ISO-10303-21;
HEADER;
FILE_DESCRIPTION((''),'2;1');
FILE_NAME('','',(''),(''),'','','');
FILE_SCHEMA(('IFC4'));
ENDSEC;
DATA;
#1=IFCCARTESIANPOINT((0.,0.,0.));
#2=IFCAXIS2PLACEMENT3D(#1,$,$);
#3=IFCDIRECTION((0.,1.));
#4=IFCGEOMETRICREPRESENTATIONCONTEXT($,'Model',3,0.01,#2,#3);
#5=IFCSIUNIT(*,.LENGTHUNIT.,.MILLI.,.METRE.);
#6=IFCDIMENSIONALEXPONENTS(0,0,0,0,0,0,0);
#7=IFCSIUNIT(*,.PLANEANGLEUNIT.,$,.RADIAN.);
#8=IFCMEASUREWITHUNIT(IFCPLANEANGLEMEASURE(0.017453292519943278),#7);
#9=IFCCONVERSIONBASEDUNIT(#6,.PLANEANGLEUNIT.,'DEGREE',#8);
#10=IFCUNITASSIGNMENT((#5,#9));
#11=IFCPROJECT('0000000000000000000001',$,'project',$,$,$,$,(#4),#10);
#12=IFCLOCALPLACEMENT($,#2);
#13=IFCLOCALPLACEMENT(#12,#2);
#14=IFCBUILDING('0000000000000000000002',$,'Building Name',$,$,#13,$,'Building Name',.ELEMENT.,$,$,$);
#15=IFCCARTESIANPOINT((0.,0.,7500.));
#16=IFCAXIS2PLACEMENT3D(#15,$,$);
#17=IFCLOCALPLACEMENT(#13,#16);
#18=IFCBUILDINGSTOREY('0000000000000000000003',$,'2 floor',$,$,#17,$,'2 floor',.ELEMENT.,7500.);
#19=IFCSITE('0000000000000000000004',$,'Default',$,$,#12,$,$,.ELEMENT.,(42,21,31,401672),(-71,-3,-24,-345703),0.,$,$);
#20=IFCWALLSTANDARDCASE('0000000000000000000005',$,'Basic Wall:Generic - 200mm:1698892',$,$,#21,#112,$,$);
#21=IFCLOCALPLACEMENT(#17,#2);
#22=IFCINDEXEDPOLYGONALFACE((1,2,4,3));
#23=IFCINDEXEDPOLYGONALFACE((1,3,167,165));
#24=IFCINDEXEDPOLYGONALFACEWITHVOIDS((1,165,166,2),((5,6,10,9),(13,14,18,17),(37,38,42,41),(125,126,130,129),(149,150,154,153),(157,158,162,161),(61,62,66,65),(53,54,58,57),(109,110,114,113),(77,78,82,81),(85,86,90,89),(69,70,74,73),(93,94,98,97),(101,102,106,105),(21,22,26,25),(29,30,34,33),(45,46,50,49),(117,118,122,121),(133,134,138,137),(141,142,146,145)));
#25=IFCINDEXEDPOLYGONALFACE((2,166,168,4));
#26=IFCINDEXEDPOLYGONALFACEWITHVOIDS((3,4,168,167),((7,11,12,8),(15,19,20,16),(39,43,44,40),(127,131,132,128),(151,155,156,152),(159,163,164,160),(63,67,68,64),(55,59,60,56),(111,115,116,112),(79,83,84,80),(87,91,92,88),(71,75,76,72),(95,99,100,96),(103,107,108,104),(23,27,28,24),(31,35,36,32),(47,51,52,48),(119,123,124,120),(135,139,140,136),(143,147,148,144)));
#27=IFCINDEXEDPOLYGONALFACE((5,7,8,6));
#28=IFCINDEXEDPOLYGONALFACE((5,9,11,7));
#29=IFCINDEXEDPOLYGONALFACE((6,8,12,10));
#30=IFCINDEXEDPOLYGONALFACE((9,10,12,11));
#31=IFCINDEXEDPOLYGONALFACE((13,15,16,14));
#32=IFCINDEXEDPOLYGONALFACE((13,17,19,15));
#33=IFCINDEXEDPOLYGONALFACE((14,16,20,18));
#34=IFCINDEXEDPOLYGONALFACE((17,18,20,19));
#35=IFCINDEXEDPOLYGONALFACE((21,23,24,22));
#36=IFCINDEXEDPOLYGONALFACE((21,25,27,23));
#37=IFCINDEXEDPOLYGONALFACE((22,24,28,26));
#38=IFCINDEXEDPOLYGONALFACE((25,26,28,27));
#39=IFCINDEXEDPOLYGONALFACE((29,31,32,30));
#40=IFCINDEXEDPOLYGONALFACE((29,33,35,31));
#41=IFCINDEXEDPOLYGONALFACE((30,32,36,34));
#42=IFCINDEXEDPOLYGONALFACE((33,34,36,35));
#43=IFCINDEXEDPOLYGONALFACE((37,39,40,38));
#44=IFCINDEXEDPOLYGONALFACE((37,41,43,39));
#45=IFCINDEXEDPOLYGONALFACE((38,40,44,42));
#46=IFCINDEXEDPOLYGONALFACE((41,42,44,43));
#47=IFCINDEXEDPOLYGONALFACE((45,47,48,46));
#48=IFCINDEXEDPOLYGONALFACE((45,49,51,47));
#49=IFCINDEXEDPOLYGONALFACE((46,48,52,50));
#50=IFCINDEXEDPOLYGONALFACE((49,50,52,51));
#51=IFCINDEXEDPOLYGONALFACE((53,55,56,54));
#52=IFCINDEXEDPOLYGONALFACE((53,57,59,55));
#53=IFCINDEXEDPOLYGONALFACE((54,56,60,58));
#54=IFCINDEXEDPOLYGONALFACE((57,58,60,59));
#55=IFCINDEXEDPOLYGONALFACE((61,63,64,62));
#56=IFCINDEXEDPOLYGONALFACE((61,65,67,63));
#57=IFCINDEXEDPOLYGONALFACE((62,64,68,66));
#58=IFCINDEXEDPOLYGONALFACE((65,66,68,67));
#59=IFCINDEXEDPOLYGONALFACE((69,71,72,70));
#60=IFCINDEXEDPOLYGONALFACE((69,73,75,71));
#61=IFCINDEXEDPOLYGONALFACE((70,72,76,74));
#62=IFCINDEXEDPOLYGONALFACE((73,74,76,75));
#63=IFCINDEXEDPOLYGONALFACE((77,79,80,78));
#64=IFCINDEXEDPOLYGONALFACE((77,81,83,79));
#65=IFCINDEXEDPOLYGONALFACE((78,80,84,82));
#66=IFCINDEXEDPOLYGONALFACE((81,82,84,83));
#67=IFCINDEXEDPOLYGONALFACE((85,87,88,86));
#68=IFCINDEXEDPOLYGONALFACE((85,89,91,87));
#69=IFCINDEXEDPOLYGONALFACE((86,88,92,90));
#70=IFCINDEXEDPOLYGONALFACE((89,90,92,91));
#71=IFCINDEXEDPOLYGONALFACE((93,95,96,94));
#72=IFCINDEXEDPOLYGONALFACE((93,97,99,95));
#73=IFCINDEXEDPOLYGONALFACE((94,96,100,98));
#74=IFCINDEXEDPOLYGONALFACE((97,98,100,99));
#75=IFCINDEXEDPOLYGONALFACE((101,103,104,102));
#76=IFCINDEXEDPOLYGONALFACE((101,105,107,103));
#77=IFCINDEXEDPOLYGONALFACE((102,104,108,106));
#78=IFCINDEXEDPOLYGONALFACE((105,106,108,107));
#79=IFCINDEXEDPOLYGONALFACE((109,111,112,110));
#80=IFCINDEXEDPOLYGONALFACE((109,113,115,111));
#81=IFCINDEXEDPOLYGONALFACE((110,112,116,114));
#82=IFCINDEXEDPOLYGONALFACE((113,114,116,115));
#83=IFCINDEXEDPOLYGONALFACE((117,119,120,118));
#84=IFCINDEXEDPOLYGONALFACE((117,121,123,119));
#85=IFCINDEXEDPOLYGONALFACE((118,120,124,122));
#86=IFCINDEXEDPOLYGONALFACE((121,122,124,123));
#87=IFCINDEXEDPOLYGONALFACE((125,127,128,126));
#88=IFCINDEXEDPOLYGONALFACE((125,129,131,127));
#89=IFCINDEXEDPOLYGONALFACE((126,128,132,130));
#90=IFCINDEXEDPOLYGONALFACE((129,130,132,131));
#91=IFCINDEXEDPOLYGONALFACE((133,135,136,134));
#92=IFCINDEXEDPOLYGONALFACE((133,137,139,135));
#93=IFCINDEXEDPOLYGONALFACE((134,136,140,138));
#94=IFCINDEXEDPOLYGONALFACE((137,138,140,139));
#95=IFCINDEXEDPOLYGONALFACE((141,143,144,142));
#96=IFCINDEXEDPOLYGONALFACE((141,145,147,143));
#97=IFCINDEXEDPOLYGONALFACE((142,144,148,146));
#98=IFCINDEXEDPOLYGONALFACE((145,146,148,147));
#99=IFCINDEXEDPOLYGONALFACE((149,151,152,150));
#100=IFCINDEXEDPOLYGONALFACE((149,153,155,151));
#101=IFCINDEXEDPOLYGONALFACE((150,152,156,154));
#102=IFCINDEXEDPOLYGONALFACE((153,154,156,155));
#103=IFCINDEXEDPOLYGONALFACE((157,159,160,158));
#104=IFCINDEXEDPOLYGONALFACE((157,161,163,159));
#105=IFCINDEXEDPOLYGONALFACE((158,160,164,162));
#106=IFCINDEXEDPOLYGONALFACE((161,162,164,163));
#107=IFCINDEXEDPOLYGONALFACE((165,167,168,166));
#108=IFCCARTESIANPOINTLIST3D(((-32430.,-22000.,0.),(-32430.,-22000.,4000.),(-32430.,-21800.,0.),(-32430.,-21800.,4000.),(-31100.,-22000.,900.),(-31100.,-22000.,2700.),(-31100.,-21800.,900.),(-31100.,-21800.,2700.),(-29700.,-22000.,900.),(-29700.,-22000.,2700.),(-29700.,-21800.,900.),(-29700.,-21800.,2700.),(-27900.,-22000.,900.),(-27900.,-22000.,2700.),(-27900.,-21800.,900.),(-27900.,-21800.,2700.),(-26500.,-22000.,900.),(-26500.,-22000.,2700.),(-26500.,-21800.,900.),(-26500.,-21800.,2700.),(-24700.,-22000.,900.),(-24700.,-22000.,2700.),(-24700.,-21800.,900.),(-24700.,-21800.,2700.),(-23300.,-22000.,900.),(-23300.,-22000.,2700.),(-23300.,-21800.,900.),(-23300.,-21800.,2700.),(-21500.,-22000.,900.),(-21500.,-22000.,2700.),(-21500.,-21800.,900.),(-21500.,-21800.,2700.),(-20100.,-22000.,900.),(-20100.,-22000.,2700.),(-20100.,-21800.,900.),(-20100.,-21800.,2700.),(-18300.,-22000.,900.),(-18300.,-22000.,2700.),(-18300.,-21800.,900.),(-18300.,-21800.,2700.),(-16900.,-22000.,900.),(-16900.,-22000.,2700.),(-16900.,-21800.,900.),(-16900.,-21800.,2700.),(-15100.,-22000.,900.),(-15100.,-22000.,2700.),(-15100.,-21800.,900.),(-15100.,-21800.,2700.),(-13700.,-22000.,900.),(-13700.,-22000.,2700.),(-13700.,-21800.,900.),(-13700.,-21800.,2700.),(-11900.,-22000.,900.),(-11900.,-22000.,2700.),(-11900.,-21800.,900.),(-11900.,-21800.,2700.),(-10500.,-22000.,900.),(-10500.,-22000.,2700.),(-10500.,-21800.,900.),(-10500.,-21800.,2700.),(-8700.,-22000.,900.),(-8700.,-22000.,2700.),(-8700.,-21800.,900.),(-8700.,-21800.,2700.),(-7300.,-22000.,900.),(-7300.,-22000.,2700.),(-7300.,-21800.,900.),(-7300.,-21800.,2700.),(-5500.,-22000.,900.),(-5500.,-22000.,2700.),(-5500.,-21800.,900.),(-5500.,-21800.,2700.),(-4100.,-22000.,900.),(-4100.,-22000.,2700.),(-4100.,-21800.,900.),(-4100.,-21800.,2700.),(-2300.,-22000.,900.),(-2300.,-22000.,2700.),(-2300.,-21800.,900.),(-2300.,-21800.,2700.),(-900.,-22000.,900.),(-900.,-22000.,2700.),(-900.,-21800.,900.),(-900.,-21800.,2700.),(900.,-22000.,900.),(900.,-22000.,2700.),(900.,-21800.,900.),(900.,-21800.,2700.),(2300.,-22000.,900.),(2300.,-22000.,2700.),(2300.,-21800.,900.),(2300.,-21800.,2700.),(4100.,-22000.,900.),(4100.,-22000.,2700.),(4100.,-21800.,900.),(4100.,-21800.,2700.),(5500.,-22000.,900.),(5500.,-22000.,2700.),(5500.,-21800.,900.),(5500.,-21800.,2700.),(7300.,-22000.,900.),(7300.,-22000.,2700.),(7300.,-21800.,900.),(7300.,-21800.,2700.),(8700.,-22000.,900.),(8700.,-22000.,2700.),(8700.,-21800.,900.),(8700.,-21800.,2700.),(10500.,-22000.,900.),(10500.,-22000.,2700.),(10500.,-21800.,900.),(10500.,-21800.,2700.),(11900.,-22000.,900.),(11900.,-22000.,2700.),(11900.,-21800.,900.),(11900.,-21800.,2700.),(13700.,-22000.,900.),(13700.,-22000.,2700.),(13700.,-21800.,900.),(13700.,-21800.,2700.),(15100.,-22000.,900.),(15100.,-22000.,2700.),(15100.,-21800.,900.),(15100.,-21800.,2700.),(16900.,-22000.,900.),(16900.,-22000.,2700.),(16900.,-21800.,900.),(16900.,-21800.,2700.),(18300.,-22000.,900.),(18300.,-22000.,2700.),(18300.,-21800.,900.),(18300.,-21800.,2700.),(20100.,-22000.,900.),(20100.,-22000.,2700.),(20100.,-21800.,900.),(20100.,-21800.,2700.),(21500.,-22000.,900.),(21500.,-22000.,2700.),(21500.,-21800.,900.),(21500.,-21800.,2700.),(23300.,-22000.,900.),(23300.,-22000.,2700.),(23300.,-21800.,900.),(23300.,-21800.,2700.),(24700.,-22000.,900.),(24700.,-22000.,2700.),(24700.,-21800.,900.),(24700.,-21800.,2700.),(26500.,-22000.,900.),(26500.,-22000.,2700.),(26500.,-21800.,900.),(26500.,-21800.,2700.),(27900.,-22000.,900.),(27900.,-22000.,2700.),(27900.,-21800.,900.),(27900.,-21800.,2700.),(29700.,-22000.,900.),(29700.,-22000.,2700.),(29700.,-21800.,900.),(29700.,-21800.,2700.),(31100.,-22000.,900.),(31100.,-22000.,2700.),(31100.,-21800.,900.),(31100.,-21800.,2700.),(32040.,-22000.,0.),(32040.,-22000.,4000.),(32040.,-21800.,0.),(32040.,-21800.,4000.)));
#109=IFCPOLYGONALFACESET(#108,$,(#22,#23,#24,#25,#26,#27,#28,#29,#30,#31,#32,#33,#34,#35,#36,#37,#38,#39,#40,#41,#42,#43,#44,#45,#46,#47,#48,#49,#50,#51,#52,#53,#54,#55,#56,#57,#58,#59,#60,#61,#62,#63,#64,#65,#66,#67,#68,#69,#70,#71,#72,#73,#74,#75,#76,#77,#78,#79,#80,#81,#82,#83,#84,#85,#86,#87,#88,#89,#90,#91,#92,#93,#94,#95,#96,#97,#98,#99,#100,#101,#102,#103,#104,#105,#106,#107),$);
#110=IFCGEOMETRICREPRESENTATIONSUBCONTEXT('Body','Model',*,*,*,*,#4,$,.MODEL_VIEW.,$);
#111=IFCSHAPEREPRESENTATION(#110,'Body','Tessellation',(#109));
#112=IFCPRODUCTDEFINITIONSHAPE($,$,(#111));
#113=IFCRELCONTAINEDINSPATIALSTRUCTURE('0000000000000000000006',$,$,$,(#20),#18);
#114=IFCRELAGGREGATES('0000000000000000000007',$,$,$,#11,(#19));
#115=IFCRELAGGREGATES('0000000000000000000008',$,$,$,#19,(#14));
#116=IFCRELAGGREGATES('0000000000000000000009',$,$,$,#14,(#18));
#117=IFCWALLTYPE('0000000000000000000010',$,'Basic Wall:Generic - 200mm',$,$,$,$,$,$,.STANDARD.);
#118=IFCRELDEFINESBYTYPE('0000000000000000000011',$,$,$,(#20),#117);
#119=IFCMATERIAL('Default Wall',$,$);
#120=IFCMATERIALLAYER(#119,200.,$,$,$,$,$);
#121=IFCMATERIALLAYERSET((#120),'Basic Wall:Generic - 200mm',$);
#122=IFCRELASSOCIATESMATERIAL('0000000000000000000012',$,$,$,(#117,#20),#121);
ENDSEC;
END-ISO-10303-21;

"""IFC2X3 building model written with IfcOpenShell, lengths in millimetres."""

from ifc_helpers import new_model, entity, si_unit, converted_unit, direction, frame, frame_2d, origin, place, context, subcontext, project, spatial, rectangle, extrude, material, layer, layer_set, layer_usage, type_object, element, save


model = new_model("IFC2X3")

# Units and contexts
model_context = context("Model", 3, precision=0.01, world=origin(), true_north=direction((0.0, 1.0)))
body_context = subcontext(model_context, "Body", "Model", "MODEL_VIEW")
ifc_project = project(units=[si_unit("LENGTHUNIT", "METRE", prefix="MILLI"), converted_unit("PLANEANGLEUNIT", "DEGREE", entity("IfcPlaneAngleMeasure", 0.017453292519943278), si_unit("PLANEANGLEUNIT", "RADIAN"), dimensions=[0, 0, 0, 0, 0, 0, 0])], contexts=[model_context])

# Site, building, storey
site_placement = place(None, origin())
site = spatial("IfcSite", under=ifc_project, at=site_placement, Name="Default", CompositionType="ELEMENT", RefLatitude=(42, 21, 31, 401672), RefLongitude=(-71, -3, -24, -345703), RefElevation=0.0)
building_placement = place(site_placement, origin())
building = spatial("IfcBuilding", under=site, at=building_placement, Name="Building Name", LongName="Building Name", CompositionType="ELEMENT")
storey_placement = place(building_placement, frame((0.0, 0.0, 7500.0)))
storey = spatial("IfcBuildingStorey", under=building, at=storey_placement, Name="2 floor", LongName="2 floor", CompositionType="ELEMENT", Elevation=7500.0)

# Wall, openings
ifc_material_1 = material(Name="Default Wall")
ifc_layer = layer(ifc_material_1, 200.0)
ifc_layer_set = layer_set([ifc_layer], Name="Basic Wall:Generic - 200mm")
ifc_layer_usage = layer_usage(ifc_layer_set, "AXIS2", "NEGATIVE", 100.0)
wall_type = type_object("IfcWallType", Name="Basic Wall:Generic - 200mm", PredefinedType="STANDARD", material=ifc_layer_set)
wall_placement = place(storey_placement, frame((32040.0, -21900.0, 0.0), z_axis=(0.0, 0.0, 1.0), x_axis=(-1.0, 0.0, 0.0)))
wall = element("IfcWallStandardCase", 1, at=wall_placement, inside=storey, type_object=wall_type, material=ifc_layer_usage, Name="Basic Wall:Generic - 200mm:1698892", context=body_context, shape_type="SweptSolid", body=[
    extrude(rectangle(XDim=64470.0, YDim=200.0, at=frame_2d((32235.0, 0.0), x_axis=(-1.0, 0.0))), origin(), (0.0, 0.0, 1.0), 4000.0),
])
opening_1_placement = place(wall_placement, frame((61740.0, -100.0, 900.0)))
element("IfcOpeningElement", 2, at=opening_1_placement, cuts=wall, ObjectType="Opening", context=body_context, shape_type="SweptSolid", body=[
    extrude(rectangle(XDim=1800.0, YDim=1400.0, at=frame_2d((900.0, 700.0), x_axis=(-1.0, 0.0))), frame((0.0, 0.0, 0.0), z_axis=(0.0, 1.0, 0.0), x_axis=(0.0, 0.0, 1.0)), (0.0, 0.0, 1.0), 200.0),
])
opening_2_placement = place(wall_placement, frame((58540.0, -100.0, 900.0)))
element("IfcOpeningElement", 3, at=opening_2_placement, cuts=wall, ObjectType="Opening", context=body_context, shape_type="SweptSolid", body=[
    extrude(rectangle(XDim=1800.0, YDim=1400.0, at=frame_2d((900.0, 700.0), x_axis=(-1.0, 0.0))), frame((0.0, 0.0, 0.0), z_axis=(0.0, 1.0, 0.0), x_axis=(0.0, 0.0, 1.0)), (0.0, 0.0, 1.0), 200.0),
])
opening_3_placement = place(wall_placement, frame((55340.0, -100.0, 900.0)))
element("IfcOpeningElement", 4, at=opening_3_placement, cuts=wall, ObjectType="Opening", context=body_context, shape_type="SweptSolid", body=[
    extrude(rectangle(XDim=1800.0, YDim=1400.0, at=frame_2d((900.0, 700.0), x_axis=(-1.0, 0.0))), frame((0.0, 0.0, 0.0), z_axis=(0.0, 1.0, 0.0), x_axis=(0.0, 0.0, 1.0)), (0.0, 0.0, 1.0), 200.0),
])
opening_4_placement = place(wall_placement, frame((52140.0, -100.0, 900.0)))
element("IfcOpeningElement", 5, at=opening_4_placement, cuts=wall, ObjectType="Opening", context=body_context, shape_type="SweptSolid", body=[
    extrude(rectangle(XDim=1800.0, YDim=1400.0, at=frame_2d((900.0, 700.0), x_axis=(-1.0, 0.0))), frame((0.0, 0.0, 0.0), z_axis=(0.0, 1.0, 0.0), x_axis=(0.0, 0.0, 1.0)), (0.0, 0.0, 1.0), 200.0),
])
opening_5_placement = place(wall_placement, frame((48940.0, -100.0, 900.0)))
element("IfcOpeningElement", 6, at=opening_5_placement, cuts=wall, ObjectType="Opening", context=body_context, shape_type="SweptSolid", body=[
    extrude(rectangle(XDim=1800.0, YDim=1400.0, at=frame_2d((900.0, 700.0), x_axis=(-1.0, 0.0))), frame((0.0, 0.0, 0.0), z_axis=(0.0, 1.0, 0.0), x_axis=(0.0, 0.0, 1.0)), (0.0, 0.0, 1.0), 200.0),
])
opening_6_placement = place(wall_placement, frame((45740.0, -100.0, 900.0)))
element("IfcOpeningElement", 7, at=opening_6_placement, cuts=wall, ObjectType="Opening", context=body_context, shape_type="SweptSolid", body=[
    extrude(rectangle(XDim=1800.0, YDim=1400.0, at=frame_2d((900.0, 700.0), x_axis=(-1.0, 0.0))), frame((0.0, 0.0, 0.0), z_axis=(0.0, 1.0, 0.0), x_axis=(0.0, 0.0, 1.0)), (0.0, 0.0, 1.0), 200.0),
])
opening_7_placement = place(wall_placement, frame((42540.0, -100.0, 900.0)))
element("IfcOpeningElement", 8, at=opening_7_placement, cuts=wall, ObjectType="Opening", context=body_context, shape_type="SweptSolid", body=[
    extrude(rectangle(XDim=1800.0, YDim=1400.0, at=frame_2d((900.0, 700.0), x_axis=(-1.0, 0.0))), frame((0.0, 0.0, 0.0), z_axis=(0.0, 1.0, 0.0), x_axis=(0.0, 0.0, 1.0)), (0.0, 0.0, 1.0), 200.0),
])
opening_8_placement = place(wall_placement, frame((39340.0, -100.0, 900.0)))
element("IfcOpeningElement", 9, at=opening_8_placement, cuts=wall, ObjectType="Opening", context=body_context, shape_type="SweptSolid", body=[
    extrude(rectangle(XDim=1800.0, YDim=1400.0, at=frame_2d((900.0, 700.0), x_axis=(-1.0, 0.0))), frame((0.0, 0.0, 0.0), z_axis=(0.0, 1.0, 0.0), x_axis=(0.0, 0.0, 1.0)), (0.0, 0.0, 1.0), 200.0),
])
opening_9_placement = place(wall_placement, frame((36140.0, -100.0, 900.0)))
element("IfcOpeningElement", 10, at=opening_9_placement, cuts=wall, ObjectType="Opening", context=body_context, shape_type="SweptSolid", body=[
    extrude(rectangle(XDim=1800.0, YDim=1400.0, at=frame_2d((900.0, 700.0), x_axis=(-1.0, 0.0))), frame((0.0, 0.0, 0.0), z_axis=(0.0, 1.0, 0.0), x_axis=(0.0, 0.0, 1.0)), (0.0, 0.0, 1.0), 200.0),
])
opening_10_placement = place(wall_placement, frame((32940.0, -100.0, 900.0)))
element("IfcOpeningElement", 11, at=opening_10_placement, cuts=wall, ObjectType="Opening", context=body_context, shape_type="SweptSolid", body=[
    extrude(rectangle(XDim=1800.0, YDim=1400.0, at=frame_2d((900.0, 700.0), x_axis=(-1.0, 0.0))), frame((0.0, 0.0, 0.0), z_axis=(0.0, 1.0, 0.0), x_axis=(0.0, 0.0, 1.0)), (0.0, 0.0, 1.0), 200.0),
])
opening_11_placement = place(wall_placement, frame((29740.0, -100.0, 900.0)))
element("IfcOpeningElement", 12, at=opening_11_placement, cuts=wall, ObjectType="Opening", context=body_context, shape_type="SweptSolid", body=[
    extrude(rectangle(XDim=1800.0, YDim=1400.0, at=frame_2d((900.0, 700.0), x_axis=(-1.0, 0.0))), frame((0.0, 0.0, 0.0), z_axis=(0.0, 1.0, 0.0), x_axis=(0.0, 0.0, 1.0)), (0.0, 0.0, 1.0), 200.0),
])
opening_12_placement = place(wall_placement, frame((26540.0, -100.0, 900.0)))
element("IfcOpeningElement", 13, at=opening_12_placement, cuts=wall, ObjectType="Opening", context=body_context, shape_type="SweptSolid", body=[
    extrude(rectangle(XDim=1800.0, YDim=1400.0, at=frame_2d((900.0, 700.0), x_axis=(-1.0, 0.0))), frame((0.0, 0.0, 0.0), z_axis=(0.0, 1.0, 0.0), x_axis=(0.0, 0.0, 1.0)), (0.0, 0.0, 1.0), 200.0),
])
opening_13_placement = place(wall_placement, frame((23340.0, -100.0, 900.0)))
element("IfcOpeningElement", 14, at=opening_13_placement, cuts=wall, ObjectType="Opening", context=body_context, shape_type="SweptSolid", body=[
    extrude(rectangle(XDim=1800.0, YDim=1400.0, at=frame_2d((900.0, 700.0), x_axis=(-1.0, 0.0))), frame((0.0, 0.0, 0.0), z_axis=(0.0, 1.0, 0.0), x_axis=(0.0, 0.0, 1.0)), (0.0, 0.0, 1.0), 200.0),
])
opening_14_placement = place(wall_placement, frame((20140.0, -100.0, 900.0)))
element("IfcOpeningElement", 15, at=opening_14_placement, cuts=wall, ObjectType="Opening", context=body_context, shape_type="SweptSolid", body=[
    extrude(rectangle(XDim=1800.0, YDim=1400.0, at=frame_2d((900.0, 700.0), x_axis=(-1.0, 0.0))), frame((0.0, 0.0, 0.0), z_axis=(0.0, 1.0, 0.0), x_axis=(0.0, 0.0, 1.0)), (0.0, 0.0, 1.0), 200.0),
])
opening_15_placement = place(wall_placement, frame((16940.0, -100.0, 900.0)))
element("IfcOpeningElement", 16, at=opening_15_placement, cuts=wall, ObjectType="Opening", context=body_context, shape_type="SweptSolid", body=[
    extrude(rectangle(XDim=1800.0, YDim=1400.0, at=frame_2d((900.0, 700.0), x_axis=(-1.0, 0.0))), frame((0.0, 0.0, 0.0), z_axis=(0.0, 1.0, 0.0), x_axis=(0.0, 0.0, 1.0)), (0.0, 0.0, 1.0), 200.0),
])
opening_16_placement = place(wall_placement, frame((13740.0, -100.0, 900.0)))
element("IfcOpeningElement", 17, at=opening_16_placement, cuts=wall, ObjectType="Opening", context=body_context, shape_type="SweptSolid", body=[
    extrude(rectangle(XDim=1800.0, YDim=1400.0, at=frame_2d((900.0, 700.0), x_axis=(-1.0, 0.0))), frame((0.0, 0.0, 0.0), z_axis=(0.0, 1.0, 0.0), x_axis=(0.0, 0.0, 1.0)), (0.0, 0.0, 1.0), 200.0),
])
opening_17_placement = place(wall_placement, frame((10540.0, -100.0, 900.0)))
element("IfcOpeningElement", 18, at=opening_17_placement, cuts=wall, ObjectType="Opening", context=body_context, shape_type="SweptSolid", body=[
    extrude(rectangle(XDim=1800.0, YDim=1400.0, at=frame_2d((900.0, 700.0), x_axis=(-1.0, 0.0))), frame((0.0, 0.0, 0.0), z_axis=(0.0, 1.0, 0.0), x_axis=(0.0, 0.0, 1.0)), (0.0, 0.0, 1.0), 200.0),
])
opening_18_placement = place(wall_placement, frame((7340.0, -100.0, 900.0)))
element("IfcOpeningElement", 19, at=opening_18_placement, cuts=wall, ObjectType="Opening", context=body_context, shape_type="SweptSolid", body=[
    extrude(rectangle(XDim=1800.0, YDim=1400.0, at=frame_2d((900.0, 700.0), x_axis=(-1.0, 0.0))), frame((0.0, 0.0, 0.0), z_axis=(0.0, 1.0, 0.0), x_axis=(0.0, 0.0, 1.0)), (0.0, 0.0, 1.0), 200.0),
])
opening_19_placement = place(wall_placement, frame((4140.0, -100.0, 900.0)))
element("IfcOpeningElement", 20, at=opening_19_placement, cuts=wall, ObjectType="Opening", context=body_context, shape_type="SweptSolid", body=[
    extrude(rectangle(XDim=1800.0, YDim=1400.0, at=frame_2d((900.0, 700.0), x_axis=(-1.0, 0.0))), frame((0.0, 0.0, 0.0), z_axis=(0.0, 1.0, 0.0), x_axis=(0.0, 0.0, 1.0)), (0.0, 0.0, 1.0), 200.0),
])
opening_20_placement = place(wall_placement, frame((940.0, -100.0, 900.0)))
element("IfcOpeningElement", 21, at=opening_20_placement, cuts=wall, ObjectType="Opening", context=body_context, shape_type="SweptSolid", body=[
    extrude(rectangle(XDim=1800.0, YDim=1400.0, at=frame_2d((900.0, 700.0), x_axis=(-1.0, 0.0))), frame((0.0, 0.0, 0.0), z_axis=(0.0, 1.0, 0.0), x_axis=(0.0, 0.0, 1.0)), (0.0, 0.0, 1.0), 200.0),
])

save(model, "model.ifc")
